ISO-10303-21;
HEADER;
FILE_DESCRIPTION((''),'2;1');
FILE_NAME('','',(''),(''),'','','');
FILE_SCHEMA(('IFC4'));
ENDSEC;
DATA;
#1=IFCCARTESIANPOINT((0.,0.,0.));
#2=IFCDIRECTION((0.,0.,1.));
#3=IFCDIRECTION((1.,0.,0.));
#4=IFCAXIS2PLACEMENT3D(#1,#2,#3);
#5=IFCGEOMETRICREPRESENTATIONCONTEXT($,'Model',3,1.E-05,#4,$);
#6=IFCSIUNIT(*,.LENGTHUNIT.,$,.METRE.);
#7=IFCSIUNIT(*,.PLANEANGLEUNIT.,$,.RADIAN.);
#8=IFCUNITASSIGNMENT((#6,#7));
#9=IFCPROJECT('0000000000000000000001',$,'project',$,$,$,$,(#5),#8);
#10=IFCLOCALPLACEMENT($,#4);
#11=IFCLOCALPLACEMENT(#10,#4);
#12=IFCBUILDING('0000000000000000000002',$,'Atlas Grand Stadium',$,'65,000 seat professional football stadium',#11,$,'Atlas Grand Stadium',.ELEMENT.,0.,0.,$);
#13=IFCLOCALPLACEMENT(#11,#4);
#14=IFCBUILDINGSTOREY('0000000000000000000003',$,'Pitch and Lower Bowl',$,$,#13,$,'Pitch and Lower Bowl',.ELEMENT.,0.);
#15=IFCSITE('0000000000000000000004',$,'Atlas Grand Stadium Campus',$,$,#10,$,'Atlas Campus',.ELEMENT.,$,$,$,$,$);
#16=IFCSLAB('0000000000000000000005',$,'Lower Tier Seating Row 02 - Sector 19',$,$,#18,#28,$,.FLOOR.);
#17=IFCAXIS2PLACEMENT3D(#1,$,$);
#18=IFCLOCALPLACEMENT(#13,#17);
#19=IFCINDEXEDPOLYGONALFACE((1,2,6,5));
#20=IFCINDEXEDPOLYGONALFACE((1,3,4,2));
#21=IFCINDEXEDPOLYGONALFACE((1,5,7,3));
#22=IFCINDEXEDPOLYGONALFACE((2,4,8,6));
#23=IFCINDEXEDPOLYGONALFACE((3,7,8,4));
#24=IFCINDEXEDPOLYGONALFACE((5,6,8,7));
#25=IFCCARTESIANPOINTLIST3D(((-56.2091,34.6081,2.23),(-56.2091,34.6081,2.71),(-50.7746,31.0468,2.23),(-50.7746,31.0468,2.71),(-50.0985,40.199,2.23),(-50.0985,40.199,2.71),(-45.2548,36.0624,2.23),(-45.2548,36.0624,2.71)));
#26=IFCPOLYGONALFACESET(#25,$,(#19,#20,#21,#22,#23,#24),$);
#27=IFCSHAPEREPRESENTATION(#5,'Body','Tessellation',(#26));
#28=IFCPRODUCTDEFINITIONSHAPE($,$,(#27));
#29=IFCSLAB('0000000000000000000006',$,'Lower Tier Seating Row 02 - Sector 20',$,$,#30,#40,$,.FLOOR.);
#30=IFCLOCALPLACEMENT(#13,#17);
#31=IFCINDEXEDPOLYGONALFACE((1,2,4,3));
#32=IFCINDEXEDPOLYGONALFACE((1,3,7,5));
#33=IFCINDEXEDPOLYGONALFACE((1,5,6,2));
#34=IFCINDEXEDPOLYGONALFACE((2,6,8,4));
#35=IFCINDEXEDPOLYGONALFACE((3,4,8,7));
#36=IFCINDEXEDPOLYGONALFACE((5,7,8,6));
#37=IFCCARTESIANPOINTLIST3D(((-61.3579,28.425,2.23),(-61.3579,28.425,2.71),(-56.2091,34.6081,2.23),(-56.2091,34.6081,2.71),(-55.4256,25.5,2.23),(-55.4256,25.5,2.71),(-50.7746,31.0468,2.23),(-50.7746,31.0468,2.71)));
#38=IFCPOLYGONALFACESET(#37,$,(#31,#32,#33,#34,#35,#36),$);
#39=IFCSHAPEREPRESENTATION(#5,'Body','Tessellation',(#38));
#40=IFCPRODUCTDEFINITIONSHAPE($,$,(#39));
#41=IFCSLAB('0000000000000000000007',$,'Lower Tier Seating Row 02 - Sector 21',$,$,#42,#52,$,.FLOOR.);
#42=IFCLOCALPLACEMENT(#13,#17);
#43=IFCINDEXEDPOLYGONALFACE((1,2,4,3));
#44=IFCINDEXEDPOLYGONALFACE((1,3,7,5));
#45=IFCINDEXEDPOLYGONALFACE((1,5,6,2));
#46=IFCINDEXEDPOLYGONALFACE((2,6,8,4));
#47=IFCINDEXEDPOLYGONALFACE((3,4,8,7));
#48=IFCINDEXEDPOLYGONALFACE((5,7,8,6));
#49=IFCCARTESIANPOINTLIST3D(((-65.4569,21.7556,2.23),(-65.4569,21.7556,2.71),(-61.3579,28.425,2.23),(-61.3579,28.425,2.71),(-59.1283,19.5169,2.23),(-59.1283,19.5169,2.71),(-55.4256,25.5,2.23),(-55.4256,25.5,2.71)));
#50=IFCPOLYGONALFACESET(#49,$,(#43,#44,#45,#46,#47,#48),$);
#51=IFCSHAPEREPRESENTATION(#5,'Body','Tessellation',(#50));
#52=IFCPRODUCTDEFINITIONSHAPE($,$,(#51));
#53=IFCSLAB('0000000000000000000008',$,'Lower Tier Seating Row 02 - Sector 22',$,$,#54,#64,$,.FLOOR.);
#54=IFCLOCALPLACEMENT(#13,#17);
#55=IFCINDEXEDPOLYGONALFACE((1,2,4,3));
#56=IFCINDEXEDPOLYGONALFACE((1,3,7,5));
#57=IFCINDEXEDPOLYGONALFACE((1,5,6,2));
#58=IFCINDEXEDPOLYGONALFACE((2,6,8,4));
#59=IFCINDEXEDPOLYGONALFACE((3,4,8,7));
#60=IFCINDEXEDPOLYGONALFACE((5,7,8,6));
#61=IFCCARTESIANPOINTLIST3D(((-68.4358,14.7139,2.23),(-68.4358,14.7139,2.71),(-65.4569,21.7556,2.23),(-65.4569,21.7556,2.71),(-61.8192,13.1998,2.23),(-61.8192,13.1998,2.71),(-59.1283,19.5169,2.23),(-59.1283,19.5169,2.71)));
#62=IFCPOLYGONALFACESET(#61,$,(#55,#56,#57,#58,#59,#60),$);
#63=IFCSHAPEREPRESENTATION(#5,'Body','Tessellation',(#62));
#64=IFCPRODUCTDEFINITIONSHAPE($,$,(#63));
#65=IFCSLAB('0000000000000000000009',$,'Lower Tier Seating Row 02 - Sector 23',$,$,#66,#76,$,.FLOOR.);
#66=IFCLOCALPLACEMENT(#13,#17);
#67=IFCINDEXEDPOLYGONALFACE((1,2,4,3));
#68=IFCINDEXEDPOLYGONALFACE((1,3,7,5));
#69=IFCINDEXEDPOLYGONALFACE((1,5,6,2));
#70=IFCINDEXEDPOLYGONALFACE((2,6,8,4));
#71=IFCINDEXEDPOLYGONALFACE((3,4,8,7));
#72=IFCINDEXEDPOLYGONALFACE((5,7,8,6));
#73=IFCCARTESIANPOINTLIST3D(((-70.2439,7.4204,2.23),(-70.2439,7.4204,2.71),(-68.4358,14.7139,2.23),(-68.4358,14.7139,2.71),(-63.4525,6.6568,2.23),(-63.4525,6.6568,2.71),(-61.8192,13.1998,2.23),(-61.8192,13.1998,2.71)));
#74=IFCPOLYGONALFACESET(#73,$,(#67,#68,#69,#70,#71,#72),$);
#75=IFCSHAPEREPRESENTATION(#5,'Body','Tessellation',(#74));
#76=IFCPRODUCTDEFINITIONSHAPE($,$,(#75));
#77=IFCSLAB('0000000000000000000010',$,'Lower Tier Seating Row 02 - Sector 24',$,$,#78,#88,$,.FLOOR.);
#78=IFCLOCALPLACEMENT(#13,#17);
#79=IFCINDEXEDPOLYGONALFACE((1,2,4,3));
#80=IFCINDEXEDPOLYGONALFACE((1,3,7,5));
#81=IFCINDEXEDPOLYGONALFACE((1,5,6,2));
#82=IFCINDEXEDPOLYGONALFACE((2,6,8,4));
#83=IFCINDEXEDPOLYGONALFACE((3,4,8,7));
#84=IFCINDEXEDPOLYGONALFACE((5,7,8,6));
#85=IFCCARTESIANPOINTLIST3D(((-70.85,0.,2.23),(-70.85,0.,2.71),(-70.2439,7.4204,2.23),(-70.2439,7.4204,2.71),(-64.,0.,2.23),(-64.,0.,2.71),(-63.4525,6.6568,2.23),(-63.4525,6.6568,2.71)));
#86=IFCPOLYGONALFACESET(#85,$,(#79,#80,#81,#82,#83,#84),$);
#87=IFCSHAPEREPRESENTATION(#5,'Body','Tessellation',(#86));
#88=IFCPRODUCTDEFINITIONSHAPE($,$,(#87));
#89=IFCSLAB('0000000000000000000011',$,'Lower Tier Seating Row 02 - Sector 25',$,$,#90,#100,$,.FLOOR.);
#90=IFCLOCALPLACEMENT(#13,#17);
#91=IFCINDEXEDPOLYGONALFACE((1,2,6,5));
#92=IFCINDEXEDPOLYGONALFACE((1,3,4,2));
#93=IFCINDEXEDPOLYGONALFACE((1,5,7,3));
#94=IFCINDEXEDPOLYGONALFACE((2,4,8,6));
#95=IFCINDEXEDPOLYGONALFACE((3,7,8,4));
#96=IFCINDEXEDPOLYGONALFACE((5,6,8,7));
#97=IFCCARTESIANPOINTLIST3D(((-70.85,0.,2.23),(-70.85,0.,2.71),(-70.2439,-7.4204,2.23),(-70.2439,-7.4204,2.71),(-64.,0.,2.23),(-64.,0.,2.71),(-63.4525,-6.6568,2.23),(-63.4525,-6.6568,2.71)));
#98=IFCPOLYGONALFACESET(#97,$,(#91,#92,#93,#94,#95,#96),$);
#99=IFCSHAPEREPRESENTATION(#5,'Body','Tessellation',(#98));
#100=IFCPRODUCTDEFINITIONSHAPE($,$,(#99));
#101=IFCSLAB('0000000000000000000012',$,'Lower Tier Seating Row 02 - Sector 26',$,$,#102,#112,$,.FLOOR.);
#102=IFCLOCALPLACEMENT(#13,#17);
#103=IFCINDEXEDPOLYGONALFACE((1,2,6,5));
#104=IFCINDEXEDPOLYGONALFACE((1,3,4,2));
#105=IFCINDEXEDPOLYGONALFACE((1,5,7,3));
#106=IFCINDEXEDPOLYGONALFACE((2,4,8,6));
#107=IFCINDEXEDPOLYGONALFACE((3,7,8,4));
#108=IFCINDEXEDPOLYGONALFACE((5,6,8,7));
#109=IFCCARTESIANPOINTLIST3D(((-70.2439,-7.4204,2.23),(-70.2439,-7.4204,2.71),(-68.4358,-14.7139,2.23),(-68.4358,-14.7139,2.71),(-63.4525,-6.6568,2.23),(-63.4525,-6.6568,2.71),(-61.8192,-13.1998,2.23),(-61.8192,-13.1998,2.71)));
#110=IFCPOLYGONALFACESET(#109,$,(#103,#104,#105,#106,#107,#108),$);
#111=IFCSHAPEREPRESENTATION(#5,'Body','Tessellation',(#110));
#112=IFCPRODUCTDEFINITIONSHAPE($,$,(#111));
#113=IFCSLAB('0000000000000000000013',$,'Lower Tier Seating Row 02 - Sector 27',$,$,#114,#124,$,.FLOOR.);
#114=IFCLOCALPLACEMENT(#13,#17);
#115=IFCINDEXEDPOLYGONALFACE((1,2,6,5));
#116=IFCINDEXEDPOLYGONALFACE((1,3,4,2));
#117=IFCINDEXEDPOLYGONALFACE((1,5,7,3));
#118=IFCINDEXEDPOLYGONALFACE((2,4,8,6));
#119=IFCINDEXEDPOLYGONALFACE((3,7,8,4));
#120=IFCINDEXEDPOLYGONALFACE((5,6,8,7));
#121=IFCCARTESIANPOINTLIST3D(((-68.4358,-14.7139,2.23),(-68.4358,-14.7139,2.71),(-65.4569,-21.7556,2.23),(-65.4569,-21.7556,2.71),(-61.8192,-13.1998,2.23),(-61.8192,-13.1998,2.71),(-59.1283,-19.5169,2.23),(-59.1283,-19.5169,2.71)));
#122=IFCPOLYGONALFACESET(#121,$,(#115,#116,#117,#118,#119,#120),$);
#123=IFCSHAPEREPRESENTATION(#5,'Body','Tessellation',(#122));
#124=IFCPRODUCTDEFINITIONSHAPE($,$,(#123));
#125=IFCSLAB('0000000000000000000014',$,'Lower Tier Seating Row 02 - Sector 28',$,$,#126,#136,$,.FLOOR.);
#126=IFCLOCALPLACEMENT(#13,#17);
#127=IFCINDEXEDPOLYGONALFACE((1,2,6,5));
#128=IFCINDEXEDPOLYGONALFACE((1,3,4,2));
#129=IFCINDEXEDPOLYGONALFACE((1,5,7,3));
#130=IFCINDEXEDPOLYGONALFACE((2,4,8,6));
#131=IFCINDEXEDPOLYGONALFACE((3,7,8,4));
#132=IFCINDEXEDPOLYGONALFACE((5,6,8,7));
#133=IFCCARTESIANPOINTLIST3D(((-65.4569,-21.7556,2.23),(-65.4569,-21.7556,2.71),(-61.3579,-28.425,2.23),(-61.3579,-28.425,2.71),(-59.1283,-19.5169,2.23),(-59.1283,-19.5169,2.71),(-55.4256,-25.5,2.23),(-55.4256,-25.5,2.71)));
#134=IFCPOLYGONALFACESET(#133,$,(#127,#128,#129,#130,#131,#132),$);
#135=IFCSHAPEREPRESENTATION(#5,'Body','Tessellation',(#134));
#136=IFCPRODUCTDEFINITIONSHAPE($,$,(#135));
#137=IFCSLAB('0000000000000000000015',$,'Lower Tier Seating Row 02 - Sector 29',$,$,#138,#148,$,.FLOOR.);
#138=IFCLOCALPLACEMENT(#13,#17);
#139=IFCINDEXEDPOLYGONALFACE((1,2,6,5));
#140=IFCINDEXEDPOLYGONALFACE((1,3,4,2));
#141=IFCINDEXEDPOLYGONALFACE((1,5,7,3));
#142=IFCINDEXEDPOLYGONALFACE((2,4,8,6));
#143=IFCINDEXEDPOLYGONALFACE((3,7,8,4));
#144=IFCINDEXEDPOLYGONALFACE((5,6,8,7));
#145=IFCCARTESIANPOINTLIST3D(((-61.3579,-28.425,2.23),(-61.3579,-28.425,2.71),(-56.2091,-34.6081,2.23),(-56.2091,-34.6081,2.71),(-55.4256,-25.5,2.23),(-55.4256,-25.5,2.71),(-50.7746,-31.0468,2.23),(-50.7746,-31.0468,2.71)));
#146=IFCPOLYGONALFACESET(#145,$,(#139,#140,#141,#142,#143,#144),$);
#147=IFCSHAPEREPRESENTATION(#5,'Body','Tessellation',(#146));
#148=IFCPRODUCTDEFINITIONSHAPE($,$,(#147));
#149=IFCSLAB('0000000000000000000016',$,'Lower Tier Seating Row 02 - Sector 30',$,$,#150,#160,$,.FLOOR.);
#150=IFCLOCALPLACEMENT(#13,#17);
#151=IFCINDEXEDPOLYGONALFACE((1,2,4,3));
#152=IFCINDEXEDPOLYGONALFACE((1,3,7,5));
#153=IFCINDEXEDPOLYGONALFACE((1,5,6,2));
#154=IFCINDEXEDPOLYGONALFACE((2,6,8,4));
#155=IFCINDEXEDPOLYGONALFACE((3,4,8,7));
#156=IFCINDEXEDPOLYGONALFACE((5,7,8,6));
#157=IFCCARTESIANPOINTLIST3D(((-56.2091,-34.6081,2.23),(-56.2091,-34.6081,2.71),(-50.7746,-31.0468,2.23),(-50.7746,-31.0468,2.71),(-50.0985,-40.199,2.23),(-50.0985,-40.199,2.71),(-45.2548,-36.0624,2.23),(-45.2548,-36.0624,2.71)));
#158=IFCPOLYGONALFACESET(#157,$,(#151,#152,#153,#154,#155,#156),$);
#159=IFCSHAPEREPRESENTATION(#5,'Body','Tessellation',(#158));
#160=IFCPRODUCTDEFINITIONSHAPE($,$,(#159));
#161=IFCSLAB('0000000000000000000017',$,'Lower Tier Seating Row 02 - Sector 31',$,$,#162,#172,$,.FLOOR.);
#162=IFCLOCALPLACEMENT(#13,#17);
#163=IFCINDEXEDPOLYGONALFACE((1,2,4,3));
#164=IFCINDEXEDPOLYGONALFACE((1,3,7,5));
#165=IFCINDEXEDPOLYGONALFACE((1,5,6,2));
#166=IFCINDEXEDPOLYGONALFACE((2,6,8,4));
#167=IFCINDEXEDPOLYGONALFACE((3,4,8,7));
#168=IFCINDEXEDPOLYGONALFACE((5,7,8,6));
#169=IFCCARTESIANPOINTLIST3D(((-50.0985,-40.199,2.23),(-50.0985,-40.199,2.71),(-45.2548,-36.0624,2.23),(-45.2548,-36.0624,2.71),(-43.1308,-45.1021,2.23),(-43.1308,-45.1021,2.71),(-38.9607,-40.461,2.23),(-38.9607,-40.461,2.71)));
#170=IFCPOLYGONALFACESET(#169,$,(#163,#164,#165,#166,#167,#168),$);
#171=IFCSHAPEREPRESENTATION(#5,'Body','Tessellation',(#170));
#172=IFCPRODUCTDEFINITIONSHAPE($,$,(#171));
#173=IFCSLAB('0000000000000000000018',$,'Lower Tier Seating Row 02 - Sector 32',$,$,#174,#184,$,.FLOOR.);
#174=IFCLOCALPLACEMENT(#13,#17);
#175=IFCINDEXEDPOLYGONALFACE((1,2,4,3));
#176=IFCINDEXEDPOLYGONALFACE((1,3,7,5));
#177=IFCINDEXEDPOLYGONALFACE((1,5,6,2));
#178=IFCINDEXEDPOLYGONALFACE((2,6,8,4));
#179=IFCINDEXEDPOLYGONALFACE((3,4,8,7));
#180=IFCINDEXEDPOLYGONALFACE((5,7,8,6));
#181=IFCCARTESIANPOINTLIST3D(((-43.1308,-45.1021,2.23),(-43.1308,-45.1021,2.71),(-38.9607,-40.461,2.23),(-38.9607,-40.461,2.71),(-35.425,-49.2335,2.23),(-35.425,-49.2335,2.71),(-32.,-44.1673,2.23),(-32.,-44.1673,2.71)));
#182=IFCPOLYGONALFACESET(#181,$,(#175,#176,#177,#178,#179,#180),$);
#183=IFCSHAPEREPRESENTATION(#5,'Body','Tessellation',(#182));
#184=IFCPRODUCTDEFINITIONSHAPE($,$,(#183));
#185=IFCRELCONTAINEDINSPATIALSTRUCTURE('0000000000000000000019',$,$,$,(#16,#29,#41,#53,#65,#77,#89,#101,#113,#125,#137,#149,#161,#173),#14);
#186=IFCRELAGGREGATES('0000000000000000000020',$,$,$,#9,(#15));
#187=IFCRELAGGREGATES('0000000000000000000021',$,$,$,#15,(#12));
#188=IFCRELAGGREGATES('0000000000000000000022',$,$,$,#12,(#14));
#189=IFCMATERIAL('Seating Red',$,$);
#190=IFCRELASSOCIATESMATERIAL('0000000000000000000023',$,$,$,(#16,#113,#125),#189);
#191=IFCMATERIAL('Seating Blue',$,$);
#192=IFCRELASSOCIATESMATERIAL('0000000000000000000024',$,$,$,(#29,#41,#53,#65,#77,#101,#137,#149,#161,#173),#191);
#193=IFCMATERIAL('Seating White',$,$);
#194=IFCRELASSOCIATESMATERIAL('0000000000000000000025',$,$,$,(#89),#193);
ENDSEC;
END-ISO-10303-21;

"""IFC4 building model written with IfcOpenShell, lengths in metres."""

from ifc_helpers import new_model, si_unit, frame, origin_with_axes, place, context, project, spatial, polyline, outline, extrude, material, element, save


model = new_model("IFC4")

# Units and contexts
model_context = context("Model", 3, precision=1e-05, world=origin_with_axes())
ifc_project = project(units=[si_unit("LENGTHUNIT", "METRE"), si_unit("PLANEANGLEUNIT", "RADIAN")], contexts=[model_context])

# Site, building, storey
site_placement = place(None, origin_with_axes())
site = spatial("IfcSite", under=ifc_project, at=site_placement, Name="Atlas Grand Stadium Campus", LongName="Atlas Campus", CompositionType="ELEMENT")
building_placement = place(site_placement, origin_with_axes())
building = spatial("IfcBuilding", under=site, at=building_placement, Name="Atlas Grand Stadium", ObjectType="65,000 seat professional football stadium", LongName="Atlas Grand Stadium", CompositionType="ELEMENT", ElevationOfRefHeight=0.0, ElevationOfTerrain=0.0)
storey_placement = place(building_placement, origin_with_axes())
storey = spatial("IfcBuildingStorey", under=building, at=storey_placement, Name="Pitch and Lower Bowl", LongName="Pitch and Lower Bowl", CompositionType="ELEMENT", Elevation=0.0)

# Slabs
ifc_material_1 = material(Name="Seating Blue")
ifc_material_2 = material(Name="Seating Red")
ifc_material_3 = material(Name="Seating White")
slab_1_placement = place(storey_placement, frame((0.0, 0.0, 2.23), z_axis=(0.0, 0.0, 1.0), x_axis=(1.0, 0.0, 0.0)))
element("IfcSlab", 1, at=slab_1_placement, inside=storey, material=ifc_material_2, Name="Lower Tier Seating Row 02 - Sector 19", PredefinedType="FLOOR", context=model_context, shape_type="SweptSolid", body=[
    extrude(outline(polyline([(-50.0985, 40.199), (-56.2091, 34.6081), (-50.7746, 31.0468), (-45.2548, 36.0624), (-50.0985, 40.199)])), origin_with_axes(), (0.0, 0.0, 1.0), 0.48),
])
slab_2_placement = place(storey_placement, frame((0.0, 0.0, 2.23), z_axis=(0.0, 0.0, 1.0), x_axis=(1.0, 0.0, 0.0)))
element("IfcSlab", 2, at=slab_2_placement, inside=storey, material=ifc_material_1, Name="Lower Tier Seating Row 02 - Sector 20", PredefinedType="FLOOR", context=model_context, shape_type="SweptSolid", body=[
    extrude(outline(polyline([(-56.2091, 34.6081), (-61.3579, 28.425), (-55.4256, 25.5), (-50.7746, 31.0468), (-56.2091, 34.6081)])), origin_with_axes(), (0.0, 0.0, 1.0), 0.48),
])
slab_3_placement = place(storey_placement, frame((0.0, 0.0, 2.23), z_axis=(0.0, 0.0, 1.0), x_axis=(1.0, 0.0, 0.0)))
element("IfcSlab", 3, at=slab_3_placement, inside=storey, material=ifc_material_1, Name="Lower Tier Seating Row 02 - Sector 21", PredefinedType="FLOOR", context=model_context, shape_type="SweptSolid", body=[
    extrude(outline(polyline([(-61.3579, 28.425), (-65.4569, 21.7555), (-59.1283, 19.5169), (-55.4256, 25.5), (-61.3579, 28.425)])), origin_with_axes(), (0.0, 0.0, 1.0), 0.48),
])
slab_4_placement = place(storey_placement, frame((0.0, 0.0, 2.23), z_axis=(0.0, 0.0, 1.0), x_axis=(1.0, 0.0, 0.0)))
element("IfcSlab", 4, at=slab_4_placement, inside=storey, material=ifc_material_1, Name="Lower Tier Seating Row 02 - Sector 22", PredefinedType="FLOOR", context=model_context, shape_type="SweptSolid", body=[
    extrude(outline(polyline([(-65.4569, 21.7555), (-68.4358, 14.7139), (-61.8192, 13.1998), (-59.1283, 19.5169), (-65.4569, 21.7555)])), origin_with_axes(), (0.0, 0.0, 1.0), 0.48),
])
slab_5_placement = place(storey_placement, frame((0.0, 0.0, 2.23), z_axis=(0.0, 0.0, 1.0), x_axis=(1.0, 0.0, 0.0)))
element("IfcSlab", 5, at=slab_5_placement, inside=storey, material=ifc_material_1, Name="Lower Tier Seating Row 02 - Sector 23", PredefinedType="FLOOR", context=model_context, shape_type="SweptSolid", body=[
    extrude(outline(polyline([(-68.4358, 14.7139), (-70.2439, 7.4204), (-63.4525, 6.6568), (-61.8192, 13.1998), (-68.4358, 14.7139)])), origin_with_axes(), (0.0, 0.0, 1.0), 0.48),
])
slab_6_placement = place(storey_placement, frame((0.0, 0.0, 2.23), z_axis=(0.0, 0.0, 1.0), x_axis=(1.0, 0.0, 0.0)))
element("IfcSlab", 6, at=slab_6_placement, inside=storey, material=ifc_material_1, Name="Lower Tier Seating Row 02 - Sector 24", PredefinedType="FLOOR", context=model_context, shape_type="SweptSolid", body=[
    extrude(outline(polyline([(-70.2439, 7.4204), (-70.85, 0.0), (-64.0, 0.0), (-63.4525, 6.6568), (-70.2439, 7.4204)])), origin_with_axes(), (0.0, 0.0, 1.0), 0.48),
])
slab_7_placement = place(storey_placement, frame((0.0, 0.0, 2.23), z_axis=(0.0, 0.0, 1.0), x_axis=(1.0, 0.0, 0.0)))
element("IfcSlab", 7, at=slab_7_placement, inside=storey, material=ifc_material_3, Name="Lower Tier Seating Row 02 - Sector 25", PredefinedType="FLOOR", context=model_context, shape_type="SweptSolid", body=[
    extrude(outline(polyline([(-70.85, 0.0), (-70.2439, -7.4204), (-63.4525, -6.6568), (-64.0, 0.0), (-70.85, 0.0)])), origin_with_axes(), (0.0, 0.0, 1.0), 0.48),
])
slab_8_placement = place(storey_placement, frame((0.0, 0.0, 2.23), z_axis=(0.0, 0.0, 1.0), x_axis=(1.0, 0.0, 0.0)))
element("IfcSlab", 8, at=slab_8_placement, inside=storey, material=ifc_material_1, Name="Lower Tier Seating Row 02 - Sector 26", PredefinedType="FLOOR", context=model_context, shape_type="SweptSolid", body=[
    extrude(outline(polyline([(-70.2439, -7.4204), (-68.4358, -14.7139), (-61.8192, -13.1998), (-63.4525, -6.6568), (-70.2439, -7.4204)])), origin_with_axes(), (0.0, 0.0, 1.0), 0.48),
])
slab_9_placement = place(storey_placement, frame((0.0, 0.0, 2.23), z_axis=(0.0, 0.0, 1.0), x_axis=(1.0, 0.0, 0.0)))
element("IfcSlab", 9, at=slab_9_placement, inside=storey, material=ifc_material_2, Name="Lower Tier Seating Row 02 - Sector 27", PredefinedType="FLOOR", context=model_context, shape_type="SweptSolid", body=[
    extrude(outline(polyline([(-68.4358, -14.7139), (-65.4569, -21.7555), (-59.1283, -19.5169), (-61.8192, -13.1998), (-68.4358, -14.7139)])), origin_with_axes(), (0.0, 0.0, 1.0), 0.48),
])
slab_10_placement = place(storey_placement, frame((0.0, 0.0, 2.23), z_axis=(0.0, 0.0, 1.0), x_axis=(1.0, 0.0, 0.0)))
element("IfcSlab", 10, at=slab_10_placement, inside=storey, material=ifc_material_2, Name="Lower Tier Seating Row 02 - Sector 28", PredefinedType="FLOOR", context=model_context, shape_type="SweptSolid", body=[
    extrude(outline(polyline([(-65.4569, -21.7555), (-61.3579, -28.425), (-55.4256, -25.5), (-59.1283, -19.5169), (-65.4569, -21.7555)])), origin_with_axes(), (0.0, 0.0, 1.0), 0.48),
])
slab_11_placement = place(storey_placement, frame((0.0, 0.0, 2.23), z_axis=(0.0, 0.0, 1.0), x_axis=(1.0, 0.0, 0.0)))
element("IfcSlab", 11, at=slab_11_placement, inside=storey, material=ifc_material_1, Name="Lower Tier Seating Row 02 - Sector 29", PredefinedType="FLOOR", context=model_context, shape_type="SweptSolid", body=[
    extrude(outline(polyline([(-61.3579, -28.425), (-56.2091, -34.6081), (-50.7746, -31.0468), (-55.4256, -25.5), (-61.3579, -28.425)])), origin_with_axes(), (0.0, 0.0, 1.0), 0.48),
])
slab_12_placement = place(storey_placement, frame((0.0, 0.0, 2.23), z_axis=(0.0, 0.0, 1.0), x_axis=(1.0, 0.0, 0.0)))
element("IfcSlab", 12, at=slab_12_placement, inside=storey, material=ifc_material_1, Name="Lower Tier Seating Row 02 - Sector 30", PredefinedType="FLOOR", context=model_context, shape_type="SweptSolid", body=[
    extrude(outline(polyline([(-56.2091, -34.6081), (-50.0985, -40.199), (-45.2548, -36.0624), (-50.7746, -31.0468), (-56.2091, -34.6081)])), origin_with_axes(), (0.0, 0.0, 1.0), 0.48),
])
slab_13_placement = place(storey_placement, frame((0.0, 0.0, 2.23), z_axis=(0.0, 0.0, 1.0), x_axis=(1.0, 0.0, 0.0)))
element("IfcSlab", 13, at=slab_13_placement, inside=storey, material=ifc_material_1, Name="Lower Tier Seating Row 02 - Sector 31", PredefinedType="FLOOR", context=model_context, shape_type="SweptSolid", body=[
    extrude(outline(polyline([(-50.0985, -40.199), (-43.1307, -45.1021), (-38.9607, -40.461), (-45.2548, -36.0624), (-50.0985, -40.199)])), origin_with_axes(), (0.0, 0.0, 1.0), 0.48),
])
slab_14_placement = place(storey_placement, frame((0.0, 0.0, 2.23), z_axis=(0.0, 0.0, 1.0), x_axis=(1.0, 0.0, 0.0)))
element("IfcSlab", 14, at=slab_14_placement, inside=storey, material=ifc_material_1, Name="Lower Tier Seating Row 02 - Sector 32", PredefinedType="FLOOR", context=model_context, shape_type="SweptSolid", body=[
    extrude(outline(polyline([(-43.1307, -45.1021), (-35.425, -49.2335), (-32.0, -44.1673), (-38.9607, -40.461), (-43.1307, -45.1021)])), origin_with_axes(), (0.0, 0.0, 1.0), 0.48),
])

save(model, "model.ifc")
